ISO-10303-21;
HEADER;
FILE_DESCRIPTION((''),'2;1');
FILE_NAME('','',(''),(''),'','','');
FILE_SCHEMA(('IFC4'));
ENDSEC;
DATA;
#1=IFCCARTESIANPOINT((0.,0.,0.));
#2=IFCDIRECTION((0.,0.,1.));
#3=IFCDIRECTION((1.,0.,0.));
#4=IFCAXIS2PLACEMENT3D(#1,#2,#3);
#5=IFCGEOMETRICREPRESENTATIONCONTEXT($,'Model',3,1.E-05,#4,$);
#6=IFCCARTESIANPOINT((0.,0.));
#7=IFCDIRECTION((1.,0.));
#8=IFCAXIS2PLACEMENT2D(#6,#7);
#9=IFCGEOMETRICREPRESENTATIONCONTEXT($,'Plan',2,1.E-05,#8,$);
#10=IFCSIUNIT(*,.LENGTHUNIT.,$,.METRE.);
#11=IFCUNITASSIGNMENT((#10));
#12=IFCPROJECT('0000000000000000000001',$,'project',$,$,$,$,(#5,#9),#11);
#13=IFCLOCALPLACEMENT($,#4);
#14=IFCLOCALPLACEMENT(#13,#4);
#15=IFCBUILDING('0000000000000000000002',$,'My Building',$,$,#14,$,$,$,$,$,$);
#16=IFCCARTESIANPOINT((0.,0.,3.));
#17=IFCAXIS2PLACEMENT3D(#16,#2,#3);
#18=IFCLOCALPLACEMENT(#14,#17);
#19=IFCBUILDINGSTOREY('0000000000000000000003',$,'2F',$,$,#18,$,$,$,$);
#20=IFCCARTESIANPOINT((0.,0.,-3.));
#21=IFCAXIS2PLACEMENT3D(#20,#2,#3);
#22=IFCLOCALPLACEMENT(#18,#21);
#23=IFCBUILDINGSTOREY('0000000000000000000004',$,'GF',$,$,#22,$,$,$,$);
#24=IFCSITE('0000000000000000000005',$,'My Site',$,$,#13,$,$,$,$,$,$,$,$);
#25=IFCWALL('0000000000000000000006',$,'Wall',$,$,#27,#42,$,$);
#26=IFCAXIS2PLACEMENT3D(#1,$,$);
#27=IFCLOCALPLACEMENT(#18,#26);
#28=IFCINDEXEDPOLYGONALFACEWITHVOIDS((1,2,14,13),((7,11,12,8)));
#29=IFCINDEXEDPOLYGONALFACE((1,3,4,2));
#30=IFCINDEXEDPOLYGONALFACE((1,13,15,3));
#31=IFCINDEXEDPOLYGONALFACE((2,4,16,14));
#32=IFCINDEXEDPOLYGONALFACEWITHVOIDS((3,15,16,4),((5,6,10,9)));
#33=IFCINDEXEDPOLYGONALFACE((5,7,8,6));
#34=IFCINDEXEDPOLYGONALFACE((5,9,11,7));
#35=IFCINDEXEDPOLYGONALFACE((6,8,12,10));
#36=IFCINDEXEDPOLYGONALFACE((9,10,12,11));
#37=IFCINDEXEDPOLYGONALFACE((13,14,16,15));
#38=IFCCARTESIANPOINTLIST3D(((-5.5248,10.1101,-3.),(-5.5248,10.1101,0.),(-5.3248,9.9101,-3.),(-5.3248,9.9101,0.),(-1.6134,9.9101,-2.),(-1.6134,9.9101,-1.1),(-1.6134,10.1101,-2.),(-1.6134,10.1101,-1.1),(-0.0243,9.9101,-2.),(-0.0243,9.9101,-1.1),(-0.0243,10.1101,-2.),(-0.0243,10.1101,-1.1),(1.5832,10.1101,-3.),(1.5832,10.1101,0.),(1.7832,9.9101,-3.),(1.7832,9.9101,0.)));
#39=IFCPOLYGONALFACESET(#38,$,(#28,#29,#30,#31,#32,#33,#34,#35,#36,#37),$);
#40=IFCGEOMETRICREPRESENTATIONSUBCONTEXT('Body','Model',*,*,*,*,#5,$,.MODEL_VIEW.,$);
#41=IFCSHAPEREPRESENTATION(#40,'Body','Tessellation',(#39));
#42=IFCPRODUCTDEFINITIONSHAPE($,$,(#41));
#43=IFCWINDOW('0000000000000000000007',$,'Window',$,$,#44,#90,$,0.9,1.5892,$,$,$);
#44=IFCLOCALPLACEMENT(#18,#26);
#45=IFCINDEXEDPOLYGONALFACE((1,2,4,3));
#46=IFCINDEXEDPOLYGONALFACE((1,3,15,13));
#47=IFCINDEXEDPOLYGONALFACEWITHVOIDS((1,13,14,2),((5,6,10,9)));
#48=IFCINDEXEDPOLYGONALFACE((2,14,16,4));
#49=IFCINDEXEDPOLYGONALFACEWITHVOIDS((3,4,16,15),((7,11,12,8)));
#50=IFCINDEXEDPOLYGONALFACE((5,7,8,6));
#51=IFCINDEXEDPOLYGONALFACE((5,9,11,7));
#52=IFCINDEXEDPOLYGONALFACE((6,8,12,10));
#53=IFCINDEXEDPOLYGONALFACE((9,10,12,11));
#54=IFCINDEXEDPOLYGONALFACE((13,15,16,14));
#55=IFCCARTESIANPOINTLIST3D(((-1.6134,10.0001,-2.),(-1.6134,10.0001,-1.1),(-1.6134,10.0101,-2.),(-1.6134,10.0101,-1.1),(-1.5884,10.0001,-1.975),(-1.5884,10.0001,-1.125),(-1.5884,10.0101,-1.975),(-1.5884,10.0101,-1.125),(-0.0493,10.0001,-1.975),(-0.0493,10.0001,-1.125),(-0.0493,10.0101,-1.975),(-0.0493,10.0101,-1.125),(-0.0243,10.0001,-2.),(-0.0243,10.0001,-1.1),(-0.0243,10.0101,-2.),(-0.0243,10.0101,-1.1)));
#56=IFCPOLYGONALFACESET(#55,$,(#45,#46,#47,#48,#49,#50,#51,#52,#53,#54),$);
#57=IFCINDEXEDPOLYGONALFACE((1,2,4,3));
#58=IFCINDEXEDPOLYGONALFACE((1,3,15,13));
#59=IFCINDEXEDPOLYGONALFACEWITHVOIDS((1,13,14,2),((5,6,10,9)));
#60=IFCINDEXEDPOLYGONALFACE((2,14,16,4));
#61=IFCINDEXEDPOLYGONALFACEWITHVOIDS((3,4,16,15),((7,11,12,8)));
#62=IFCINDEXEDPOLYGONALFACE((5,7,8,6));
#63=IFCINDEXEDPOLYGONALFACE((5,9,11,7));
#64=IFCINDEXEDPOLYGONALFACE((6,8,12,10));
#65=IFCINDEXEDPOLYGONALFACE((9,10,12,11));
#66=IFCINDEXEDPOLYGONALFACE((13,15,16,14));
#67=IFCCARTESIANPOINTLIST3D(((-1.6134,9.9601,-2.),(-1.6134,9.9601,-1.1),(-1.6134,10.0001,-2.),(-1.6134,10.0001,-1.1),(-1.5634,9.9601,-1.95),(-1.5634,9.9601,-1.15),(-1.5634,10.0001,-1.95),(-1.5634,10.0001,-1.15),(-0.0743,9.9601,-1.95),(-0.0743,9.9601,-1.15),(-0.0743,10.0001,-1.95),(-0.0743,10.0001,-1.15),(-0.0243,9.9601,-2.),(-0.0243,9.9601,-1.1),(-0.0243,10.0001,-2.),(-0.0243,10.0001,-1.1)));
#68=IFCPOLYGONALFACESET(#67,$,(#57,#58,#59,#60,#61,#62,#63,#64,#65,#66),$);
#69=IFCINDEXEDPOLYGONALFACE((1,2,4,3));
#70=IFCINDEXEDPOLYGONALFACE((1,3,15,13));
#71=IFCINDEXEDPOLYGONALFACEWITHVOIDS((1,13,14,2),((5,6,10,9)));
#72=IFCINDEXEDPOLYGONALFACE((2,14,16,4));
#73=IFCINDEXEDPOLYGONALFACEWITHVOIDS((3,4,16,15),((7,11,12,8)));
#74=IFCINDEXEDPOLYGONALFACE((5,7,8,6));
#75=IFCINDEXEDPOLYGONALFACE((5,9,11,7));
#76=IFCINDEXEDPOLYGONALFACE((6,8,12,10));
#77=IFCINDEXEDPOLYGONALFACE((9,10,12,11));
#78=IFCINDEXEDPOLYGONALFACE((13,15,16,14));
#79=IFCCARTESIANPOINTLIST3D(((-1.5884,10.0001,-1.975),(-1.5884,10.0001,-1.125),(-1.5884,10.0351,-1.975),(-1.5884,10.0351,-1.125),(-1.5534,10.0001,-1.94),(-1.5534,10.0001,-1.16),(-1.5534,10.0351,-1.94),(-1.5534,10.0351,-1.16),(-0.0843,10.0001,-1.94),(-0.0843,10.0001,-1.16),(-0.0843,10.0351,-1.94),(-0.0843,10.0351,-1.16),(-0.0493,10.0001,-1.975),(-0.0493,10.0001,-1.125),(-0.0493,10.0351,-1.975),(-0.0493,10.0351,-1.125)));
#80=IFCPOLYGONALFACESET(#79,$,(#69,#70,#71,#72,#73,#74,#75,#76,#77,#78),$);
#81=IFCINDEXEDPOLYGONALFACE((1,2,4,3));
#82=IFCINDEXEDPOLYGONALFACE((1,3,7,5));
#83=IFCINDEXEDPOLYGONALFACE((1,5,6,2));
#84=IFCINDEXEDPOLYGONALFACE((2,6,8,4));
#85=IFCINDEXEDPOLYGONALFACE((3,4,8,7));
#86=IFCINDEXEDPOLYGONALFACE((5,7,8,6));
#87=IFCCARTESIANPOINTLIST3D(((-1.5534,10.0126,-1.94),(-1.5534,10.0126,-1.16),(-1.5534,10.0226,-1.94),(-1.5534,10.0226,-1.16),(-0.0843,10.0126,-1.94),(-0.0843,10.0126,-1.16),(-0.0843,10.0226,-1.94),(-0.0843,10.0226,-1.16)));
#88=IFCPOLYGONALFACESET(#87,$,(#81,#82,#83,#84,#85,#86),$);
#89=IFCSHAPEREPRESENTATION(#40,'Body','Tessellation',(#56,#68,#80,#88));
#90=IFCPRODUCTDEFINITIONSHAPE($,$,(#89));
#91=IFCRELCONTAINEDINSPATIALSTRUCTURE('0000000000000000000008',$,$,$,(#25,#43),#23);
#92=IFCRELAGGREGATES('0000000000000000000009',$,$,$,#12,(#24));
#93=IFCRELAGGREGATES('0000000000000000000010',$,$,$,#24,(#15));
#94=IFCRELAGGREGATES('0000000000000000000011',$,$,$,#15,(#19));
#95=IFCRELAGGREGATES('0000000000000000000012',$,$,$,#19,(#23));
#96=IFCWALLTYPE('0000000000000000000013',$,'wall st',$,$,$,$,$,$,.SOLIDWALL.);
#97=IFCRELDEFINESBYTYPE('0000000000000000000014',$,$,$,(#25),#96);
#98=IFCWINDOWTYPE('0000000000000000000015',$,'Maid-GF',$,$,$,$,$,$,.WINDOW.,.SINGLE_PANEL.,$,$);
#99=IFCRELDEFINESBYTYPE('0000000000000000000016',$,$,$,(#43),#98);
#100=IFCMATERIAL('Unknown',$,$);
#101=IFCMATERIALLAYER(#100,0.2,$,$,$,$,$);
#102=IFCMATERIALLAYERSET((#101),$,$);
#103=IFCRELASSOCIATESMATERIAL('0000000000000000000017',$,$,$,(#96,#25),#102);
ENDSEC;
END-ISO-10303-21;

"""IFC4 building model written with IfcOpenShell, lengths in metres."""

from ifc_helpers import new_model, entity, si_unit, frame, origin_with_axes, origin_2d_with_axis, place, context, subcontext, project, spatial, line, indexed_curve, outline, extrude, shape, source, transform, mapped, material, layer, layer_set, layer_usage, type_object, type_shapes, element, fill, save


model = new_model("IFC4")

# Units and contexts
model_context = context("Model", 3, precision=1e-05, world=origin_with_axes())
plan_context = context("Plan", 2, precision=1e-05, world=origin_2d_with_axis())
body_context_1 = subcontext(model_context, "Body", "Model", "MODEL_VIEW")
body_context_2 = subcontext(plan_context, "Body", "Plan", "PLAN_VIEW")
ifc_project = project(units=[si_unit("LENGTHUNIT", "METRE")], contexts=[model_context, plan_context])

# Site, building, storeys
site_placement = place(None, origin_with_axes())
site = spatial("IfcSite", under=ifc_project, at=site_placement, Name="My Site")
building_placement = place(site_placement, origin_with_axes())
building = spatial("IfcBuilding", under=site, at=building_placement, Name="My Building")
storey_1_placement = place(building_placement, frame((0.0, 0.0, 3.0), z_axis=(0.0, 0.0, 1.0), x_axis=(1.0, 0.0, 0.0)))
storey_1 = spatial("IfcBuildingStorey", under=building, at=storey_1_placement, Name="2F")
storey_2_placement = place(storey_1_placement, frame((0.0, 0.0, -3.0), z_axis=(0.0, 0.0, 1.0), x_axis=(1.0, 0.0, 0.0)))
storey_2 = spatial("IfcBuildingStorey", under=storey_1, at=storey_2_placement, Name="GF")

# Shared definitions
ifc_material = material(Name="Unknown")

# Shared definitions
ifc_layer_1 = layer(ifc_material, 0.2)
ifc_layer_set_1 = layer_set([ifc_layer_1])
wall_type = type_object("IfcWallType", Name="wall st", PredefinedType="SOLIDWALL", material=ifc_layer_set_1)

# Wall, opening, window
ifc_layer_usage_1 = layer_usage(ifc_layer_set_1, "AXIS2", "POSITIVE", 0.0)
wall_1_placement = place(storey_2_placement, frame((1.5832, 10.1101, 0.0), z_axis=(0.0, 0.0, 1.0), x_axis=(-1.0, 0.0, 0.0)))
wall_1 = element("IfcWall", 1, at=wall_1_placement, inside=storey_2, type_object=wall_type, material=ifc_layer_usage_1, Name="Wall", context=body_context_1, shape_type="SweptSolid", body=[
    extrude(outline(indexed_curve([(0.0, 0.0), (-0.2, 0.2), (6.908, 0.2), (7.108, 0.0)], segments=[line(1, 2, 3, 4, 1)])), origin_with_axes(), (0.0, 0.0, 1.0), 3.0),
])
shared_shape_1 = source(origin_with_axes(), body_context_1, "Body", "SweptSolid", [
    extrude(outline(indexed_curve([(0.0, 0.0), (1.5892, 0.0), (1.5892, 0.9), (0.0, 0.9)], segments=[line(1, 2, 3, 4, 1)])), frame((0.0, -0.6, 0.0), z_axis=(0.0, -1.0, 0.0), x_axis=(1.0, 0.0, 0.0)), (0.0, 0.0, -1.0), 1.2),
])
opening_1_placement = place(wall_1_placement, frame((3.1967, 0.2, 1.0), z_axis=(0.0, 0.0, 1.0), x_axis=(-1.0, 0.0, 0.0)))
opening_1 = element("IfcOpeningElement", 2, at=opening_1_placement, cuts=wall_1, PredefinedType="OPENING", context=body_context_1, shape_type="MappedRepresentation", body=[
    mapped(shared_shape_1, transform((0.0, 0.0, 0.0), x_axis=(1.0, 0.0, 0.0), y_axis=(0.0, 1.0, 0.0), z_axis=(0.0, 0.0, 1.0), scale=1.0)),
])
window_type_1 = type_object("IfcWindowType", Name="Maid-GF", PartitioningType="SINGLE_PANEL", PredefinedType="WINDOW")
shared_shape_2 = source(origin_with_axes(), body_context_1, "Body", "SweptSolid", [
    extrude(outline(indexed_curve([(0.0, 0.0), (1.5892, 0.0), (1.5892, 0.9), (0.0, 0.9)], segments=[line(1, 2, 3, 4, 1)]), holes=[indexed_curve([(0.025, 0.025), (1.5642, 0.025), (1.5642, 0.875), (0.025, 0.875)], segments=[line(1, 2, 3, 4, 1)])]), frame((0.0, 0.09, 0.0), z_axis=(0.0, -1.0, 0.0), x_axis=(1.0, 0.0, 0.0)), (0.0, 0.0, -1.0), 0.01),
    extrude(outline(indexed_curve([(0.0, 0.0), (1.5892, 0.0), (1.5892, 0.9), (0.0, 0.9)], segments=[line(1, 2, 3, 4, 1)]), holes=[indexed_curve([(0.05, 0.05), (1.5392, 0.05), (1.5392, 0.85), (0.05, 0.85)], segments=[line(1, 2, 3, 4, 1)])]), frame((0.0, 0.05, 0.0), z_axis=(0.0, -1.0, 0.0), x_axis=(1.0, 0.0, 0.0)), (0.0, 0.0, -1.0), 0.04),
    extrude(outline(indexed_curve([(0.0, 0.0), (1.5392, 0.0), (1.5392, 0.85), (0.0, 0.85)], segments=[line(1, 2, 3, 4, 1)]), holes=[indexed_curve([(0.035, 0.035), (1.5042, 0.035), (1.5042, 0.815), (0.035, 0.815)], segments=[line(1, 2, 3, 4, 1)])]), frame((0.025, 0.09, 0.025), z_axis=(0.0, -1.0, 0.0), x_axis=(1.0, 0.0, 0.0)), (0.0, 0.0, -1.0), 0.035),
    extrude(outline(indexed_curve([(0.035, 0.035), (1.5042, 0.035), (1.5042, 0.815), (0.035, 0.815)], segments=[line(1, 2, 3, 4, 1)])), frame((0.025, 0.1025, 0.025), z_axis=(0.0, -1.0, 0.0), x_axis=(1.0, 0.0, 0.0)), (0.0, 0.0, -1.0), 0.01),
])
shared_shape_3 = source(origin_with_axes(), body_context_2, "Body", "Curve2D", [
    entity("IfcIndexedPolyCurve", entity("IfcCartesianPointList2D", [[0.05, 0.05], [1.5392, 0.05]])),
    entity("IfcIndexedPolyCurve", entity("IfcCartesianPointList2D", [[0.0, 0.1], [0.025, 0.1], [0.025, 0.09], [0.05, 0.09], [0.05, 0.05], [0.0, 0.05]]), [entity("IfcLineIndex", [1, 2, 3, 4, 5, 6, 1])]),
    entity("IfcIndexedPolyCurve", entity("IfcCartesianPointList2D", [[1.5892, 0.1], [1.5642, 0.1], [1.5642, 0.09], [1.5392, 0.09], [1.5392, 0.05], [1.5892, 0.05]]), [entity("IfcLineIndex", [1, 2, 3, 4, 5, 6, 1])]),
    entity("IfcIndexedPolyCurve", entity("IfcCartesianPointList2D", [[0.025, 0.09], [0.06, 0.09], [0.06, 0.125], [0.025, 0.125]]), [entity("IfcLineIndex", [1, 2, 3, 4, 1])]),
    entity("IfcIndexedPolyCurve", entity("IfcCartesianPointList2D", [[1.5642, 0.09], [1.5292, 0.09], [1.5292, 0.125], [1.5642, 0.125]]), [entity("IfcLineIndex", [1, 2, 3, 4, 1])]),
    entity("IfcIndexedPolyCurve", entity("IfcCartesianPointList2D", [[0.06, 0.09], [1.5292, 0.09]])),
    entity("IfcIndexedPolyCurve", entity("IfcCartesianPointList2D", [[0.06, 0.125], [1.5292, 0.125]])),
    entity("IfcIndexedPolyCurve", entity("IfcCartesianPointList2D", [[0.06, 0.1075], [1.5292, 0.1075]])),
])
type_shapes(window_type_1, [shared_shape_2, shared_shape_3])
window_1_placement = place(opening_1_placement, frame((0.0, 0.0, 0.0), z_axis=(0.0, 0.0, 1.0), x_axis=(1.0, 0.0, 0.0)))
window_1 = element("IfcWindow", 3, at=window_1_placement, inside=storey_2, type_object=window_type_1, Name="Window", OverallHeight=0.9, OverallWidth=1.5892, shapes=[
    shape(body_context_1, "Body", "MappedRepresentation", [mapped(shared_shape_2, transform((0.0, 0.0, 0.0), x_axis=(1.0, 0.0, 0.0), y_axis=(0.0, 1.0, 0.0), z_axis=(0.0, 0.0, 1.0), scale=1.0))]),
    shape(body_context_2, "Body", "MappedRepresentation", [mapped(shared_shape_3, transform((0.0, 0.0, 0.0), x_axis=(1.0, 0.0, 0.0), y_axis=(0.0, 1.0, 0.0), z_axis=(0.0, 0.0, 1.0), scale=1.0))]),
])
fill(opening_1, window_1)

save(model, "model.ifc")
